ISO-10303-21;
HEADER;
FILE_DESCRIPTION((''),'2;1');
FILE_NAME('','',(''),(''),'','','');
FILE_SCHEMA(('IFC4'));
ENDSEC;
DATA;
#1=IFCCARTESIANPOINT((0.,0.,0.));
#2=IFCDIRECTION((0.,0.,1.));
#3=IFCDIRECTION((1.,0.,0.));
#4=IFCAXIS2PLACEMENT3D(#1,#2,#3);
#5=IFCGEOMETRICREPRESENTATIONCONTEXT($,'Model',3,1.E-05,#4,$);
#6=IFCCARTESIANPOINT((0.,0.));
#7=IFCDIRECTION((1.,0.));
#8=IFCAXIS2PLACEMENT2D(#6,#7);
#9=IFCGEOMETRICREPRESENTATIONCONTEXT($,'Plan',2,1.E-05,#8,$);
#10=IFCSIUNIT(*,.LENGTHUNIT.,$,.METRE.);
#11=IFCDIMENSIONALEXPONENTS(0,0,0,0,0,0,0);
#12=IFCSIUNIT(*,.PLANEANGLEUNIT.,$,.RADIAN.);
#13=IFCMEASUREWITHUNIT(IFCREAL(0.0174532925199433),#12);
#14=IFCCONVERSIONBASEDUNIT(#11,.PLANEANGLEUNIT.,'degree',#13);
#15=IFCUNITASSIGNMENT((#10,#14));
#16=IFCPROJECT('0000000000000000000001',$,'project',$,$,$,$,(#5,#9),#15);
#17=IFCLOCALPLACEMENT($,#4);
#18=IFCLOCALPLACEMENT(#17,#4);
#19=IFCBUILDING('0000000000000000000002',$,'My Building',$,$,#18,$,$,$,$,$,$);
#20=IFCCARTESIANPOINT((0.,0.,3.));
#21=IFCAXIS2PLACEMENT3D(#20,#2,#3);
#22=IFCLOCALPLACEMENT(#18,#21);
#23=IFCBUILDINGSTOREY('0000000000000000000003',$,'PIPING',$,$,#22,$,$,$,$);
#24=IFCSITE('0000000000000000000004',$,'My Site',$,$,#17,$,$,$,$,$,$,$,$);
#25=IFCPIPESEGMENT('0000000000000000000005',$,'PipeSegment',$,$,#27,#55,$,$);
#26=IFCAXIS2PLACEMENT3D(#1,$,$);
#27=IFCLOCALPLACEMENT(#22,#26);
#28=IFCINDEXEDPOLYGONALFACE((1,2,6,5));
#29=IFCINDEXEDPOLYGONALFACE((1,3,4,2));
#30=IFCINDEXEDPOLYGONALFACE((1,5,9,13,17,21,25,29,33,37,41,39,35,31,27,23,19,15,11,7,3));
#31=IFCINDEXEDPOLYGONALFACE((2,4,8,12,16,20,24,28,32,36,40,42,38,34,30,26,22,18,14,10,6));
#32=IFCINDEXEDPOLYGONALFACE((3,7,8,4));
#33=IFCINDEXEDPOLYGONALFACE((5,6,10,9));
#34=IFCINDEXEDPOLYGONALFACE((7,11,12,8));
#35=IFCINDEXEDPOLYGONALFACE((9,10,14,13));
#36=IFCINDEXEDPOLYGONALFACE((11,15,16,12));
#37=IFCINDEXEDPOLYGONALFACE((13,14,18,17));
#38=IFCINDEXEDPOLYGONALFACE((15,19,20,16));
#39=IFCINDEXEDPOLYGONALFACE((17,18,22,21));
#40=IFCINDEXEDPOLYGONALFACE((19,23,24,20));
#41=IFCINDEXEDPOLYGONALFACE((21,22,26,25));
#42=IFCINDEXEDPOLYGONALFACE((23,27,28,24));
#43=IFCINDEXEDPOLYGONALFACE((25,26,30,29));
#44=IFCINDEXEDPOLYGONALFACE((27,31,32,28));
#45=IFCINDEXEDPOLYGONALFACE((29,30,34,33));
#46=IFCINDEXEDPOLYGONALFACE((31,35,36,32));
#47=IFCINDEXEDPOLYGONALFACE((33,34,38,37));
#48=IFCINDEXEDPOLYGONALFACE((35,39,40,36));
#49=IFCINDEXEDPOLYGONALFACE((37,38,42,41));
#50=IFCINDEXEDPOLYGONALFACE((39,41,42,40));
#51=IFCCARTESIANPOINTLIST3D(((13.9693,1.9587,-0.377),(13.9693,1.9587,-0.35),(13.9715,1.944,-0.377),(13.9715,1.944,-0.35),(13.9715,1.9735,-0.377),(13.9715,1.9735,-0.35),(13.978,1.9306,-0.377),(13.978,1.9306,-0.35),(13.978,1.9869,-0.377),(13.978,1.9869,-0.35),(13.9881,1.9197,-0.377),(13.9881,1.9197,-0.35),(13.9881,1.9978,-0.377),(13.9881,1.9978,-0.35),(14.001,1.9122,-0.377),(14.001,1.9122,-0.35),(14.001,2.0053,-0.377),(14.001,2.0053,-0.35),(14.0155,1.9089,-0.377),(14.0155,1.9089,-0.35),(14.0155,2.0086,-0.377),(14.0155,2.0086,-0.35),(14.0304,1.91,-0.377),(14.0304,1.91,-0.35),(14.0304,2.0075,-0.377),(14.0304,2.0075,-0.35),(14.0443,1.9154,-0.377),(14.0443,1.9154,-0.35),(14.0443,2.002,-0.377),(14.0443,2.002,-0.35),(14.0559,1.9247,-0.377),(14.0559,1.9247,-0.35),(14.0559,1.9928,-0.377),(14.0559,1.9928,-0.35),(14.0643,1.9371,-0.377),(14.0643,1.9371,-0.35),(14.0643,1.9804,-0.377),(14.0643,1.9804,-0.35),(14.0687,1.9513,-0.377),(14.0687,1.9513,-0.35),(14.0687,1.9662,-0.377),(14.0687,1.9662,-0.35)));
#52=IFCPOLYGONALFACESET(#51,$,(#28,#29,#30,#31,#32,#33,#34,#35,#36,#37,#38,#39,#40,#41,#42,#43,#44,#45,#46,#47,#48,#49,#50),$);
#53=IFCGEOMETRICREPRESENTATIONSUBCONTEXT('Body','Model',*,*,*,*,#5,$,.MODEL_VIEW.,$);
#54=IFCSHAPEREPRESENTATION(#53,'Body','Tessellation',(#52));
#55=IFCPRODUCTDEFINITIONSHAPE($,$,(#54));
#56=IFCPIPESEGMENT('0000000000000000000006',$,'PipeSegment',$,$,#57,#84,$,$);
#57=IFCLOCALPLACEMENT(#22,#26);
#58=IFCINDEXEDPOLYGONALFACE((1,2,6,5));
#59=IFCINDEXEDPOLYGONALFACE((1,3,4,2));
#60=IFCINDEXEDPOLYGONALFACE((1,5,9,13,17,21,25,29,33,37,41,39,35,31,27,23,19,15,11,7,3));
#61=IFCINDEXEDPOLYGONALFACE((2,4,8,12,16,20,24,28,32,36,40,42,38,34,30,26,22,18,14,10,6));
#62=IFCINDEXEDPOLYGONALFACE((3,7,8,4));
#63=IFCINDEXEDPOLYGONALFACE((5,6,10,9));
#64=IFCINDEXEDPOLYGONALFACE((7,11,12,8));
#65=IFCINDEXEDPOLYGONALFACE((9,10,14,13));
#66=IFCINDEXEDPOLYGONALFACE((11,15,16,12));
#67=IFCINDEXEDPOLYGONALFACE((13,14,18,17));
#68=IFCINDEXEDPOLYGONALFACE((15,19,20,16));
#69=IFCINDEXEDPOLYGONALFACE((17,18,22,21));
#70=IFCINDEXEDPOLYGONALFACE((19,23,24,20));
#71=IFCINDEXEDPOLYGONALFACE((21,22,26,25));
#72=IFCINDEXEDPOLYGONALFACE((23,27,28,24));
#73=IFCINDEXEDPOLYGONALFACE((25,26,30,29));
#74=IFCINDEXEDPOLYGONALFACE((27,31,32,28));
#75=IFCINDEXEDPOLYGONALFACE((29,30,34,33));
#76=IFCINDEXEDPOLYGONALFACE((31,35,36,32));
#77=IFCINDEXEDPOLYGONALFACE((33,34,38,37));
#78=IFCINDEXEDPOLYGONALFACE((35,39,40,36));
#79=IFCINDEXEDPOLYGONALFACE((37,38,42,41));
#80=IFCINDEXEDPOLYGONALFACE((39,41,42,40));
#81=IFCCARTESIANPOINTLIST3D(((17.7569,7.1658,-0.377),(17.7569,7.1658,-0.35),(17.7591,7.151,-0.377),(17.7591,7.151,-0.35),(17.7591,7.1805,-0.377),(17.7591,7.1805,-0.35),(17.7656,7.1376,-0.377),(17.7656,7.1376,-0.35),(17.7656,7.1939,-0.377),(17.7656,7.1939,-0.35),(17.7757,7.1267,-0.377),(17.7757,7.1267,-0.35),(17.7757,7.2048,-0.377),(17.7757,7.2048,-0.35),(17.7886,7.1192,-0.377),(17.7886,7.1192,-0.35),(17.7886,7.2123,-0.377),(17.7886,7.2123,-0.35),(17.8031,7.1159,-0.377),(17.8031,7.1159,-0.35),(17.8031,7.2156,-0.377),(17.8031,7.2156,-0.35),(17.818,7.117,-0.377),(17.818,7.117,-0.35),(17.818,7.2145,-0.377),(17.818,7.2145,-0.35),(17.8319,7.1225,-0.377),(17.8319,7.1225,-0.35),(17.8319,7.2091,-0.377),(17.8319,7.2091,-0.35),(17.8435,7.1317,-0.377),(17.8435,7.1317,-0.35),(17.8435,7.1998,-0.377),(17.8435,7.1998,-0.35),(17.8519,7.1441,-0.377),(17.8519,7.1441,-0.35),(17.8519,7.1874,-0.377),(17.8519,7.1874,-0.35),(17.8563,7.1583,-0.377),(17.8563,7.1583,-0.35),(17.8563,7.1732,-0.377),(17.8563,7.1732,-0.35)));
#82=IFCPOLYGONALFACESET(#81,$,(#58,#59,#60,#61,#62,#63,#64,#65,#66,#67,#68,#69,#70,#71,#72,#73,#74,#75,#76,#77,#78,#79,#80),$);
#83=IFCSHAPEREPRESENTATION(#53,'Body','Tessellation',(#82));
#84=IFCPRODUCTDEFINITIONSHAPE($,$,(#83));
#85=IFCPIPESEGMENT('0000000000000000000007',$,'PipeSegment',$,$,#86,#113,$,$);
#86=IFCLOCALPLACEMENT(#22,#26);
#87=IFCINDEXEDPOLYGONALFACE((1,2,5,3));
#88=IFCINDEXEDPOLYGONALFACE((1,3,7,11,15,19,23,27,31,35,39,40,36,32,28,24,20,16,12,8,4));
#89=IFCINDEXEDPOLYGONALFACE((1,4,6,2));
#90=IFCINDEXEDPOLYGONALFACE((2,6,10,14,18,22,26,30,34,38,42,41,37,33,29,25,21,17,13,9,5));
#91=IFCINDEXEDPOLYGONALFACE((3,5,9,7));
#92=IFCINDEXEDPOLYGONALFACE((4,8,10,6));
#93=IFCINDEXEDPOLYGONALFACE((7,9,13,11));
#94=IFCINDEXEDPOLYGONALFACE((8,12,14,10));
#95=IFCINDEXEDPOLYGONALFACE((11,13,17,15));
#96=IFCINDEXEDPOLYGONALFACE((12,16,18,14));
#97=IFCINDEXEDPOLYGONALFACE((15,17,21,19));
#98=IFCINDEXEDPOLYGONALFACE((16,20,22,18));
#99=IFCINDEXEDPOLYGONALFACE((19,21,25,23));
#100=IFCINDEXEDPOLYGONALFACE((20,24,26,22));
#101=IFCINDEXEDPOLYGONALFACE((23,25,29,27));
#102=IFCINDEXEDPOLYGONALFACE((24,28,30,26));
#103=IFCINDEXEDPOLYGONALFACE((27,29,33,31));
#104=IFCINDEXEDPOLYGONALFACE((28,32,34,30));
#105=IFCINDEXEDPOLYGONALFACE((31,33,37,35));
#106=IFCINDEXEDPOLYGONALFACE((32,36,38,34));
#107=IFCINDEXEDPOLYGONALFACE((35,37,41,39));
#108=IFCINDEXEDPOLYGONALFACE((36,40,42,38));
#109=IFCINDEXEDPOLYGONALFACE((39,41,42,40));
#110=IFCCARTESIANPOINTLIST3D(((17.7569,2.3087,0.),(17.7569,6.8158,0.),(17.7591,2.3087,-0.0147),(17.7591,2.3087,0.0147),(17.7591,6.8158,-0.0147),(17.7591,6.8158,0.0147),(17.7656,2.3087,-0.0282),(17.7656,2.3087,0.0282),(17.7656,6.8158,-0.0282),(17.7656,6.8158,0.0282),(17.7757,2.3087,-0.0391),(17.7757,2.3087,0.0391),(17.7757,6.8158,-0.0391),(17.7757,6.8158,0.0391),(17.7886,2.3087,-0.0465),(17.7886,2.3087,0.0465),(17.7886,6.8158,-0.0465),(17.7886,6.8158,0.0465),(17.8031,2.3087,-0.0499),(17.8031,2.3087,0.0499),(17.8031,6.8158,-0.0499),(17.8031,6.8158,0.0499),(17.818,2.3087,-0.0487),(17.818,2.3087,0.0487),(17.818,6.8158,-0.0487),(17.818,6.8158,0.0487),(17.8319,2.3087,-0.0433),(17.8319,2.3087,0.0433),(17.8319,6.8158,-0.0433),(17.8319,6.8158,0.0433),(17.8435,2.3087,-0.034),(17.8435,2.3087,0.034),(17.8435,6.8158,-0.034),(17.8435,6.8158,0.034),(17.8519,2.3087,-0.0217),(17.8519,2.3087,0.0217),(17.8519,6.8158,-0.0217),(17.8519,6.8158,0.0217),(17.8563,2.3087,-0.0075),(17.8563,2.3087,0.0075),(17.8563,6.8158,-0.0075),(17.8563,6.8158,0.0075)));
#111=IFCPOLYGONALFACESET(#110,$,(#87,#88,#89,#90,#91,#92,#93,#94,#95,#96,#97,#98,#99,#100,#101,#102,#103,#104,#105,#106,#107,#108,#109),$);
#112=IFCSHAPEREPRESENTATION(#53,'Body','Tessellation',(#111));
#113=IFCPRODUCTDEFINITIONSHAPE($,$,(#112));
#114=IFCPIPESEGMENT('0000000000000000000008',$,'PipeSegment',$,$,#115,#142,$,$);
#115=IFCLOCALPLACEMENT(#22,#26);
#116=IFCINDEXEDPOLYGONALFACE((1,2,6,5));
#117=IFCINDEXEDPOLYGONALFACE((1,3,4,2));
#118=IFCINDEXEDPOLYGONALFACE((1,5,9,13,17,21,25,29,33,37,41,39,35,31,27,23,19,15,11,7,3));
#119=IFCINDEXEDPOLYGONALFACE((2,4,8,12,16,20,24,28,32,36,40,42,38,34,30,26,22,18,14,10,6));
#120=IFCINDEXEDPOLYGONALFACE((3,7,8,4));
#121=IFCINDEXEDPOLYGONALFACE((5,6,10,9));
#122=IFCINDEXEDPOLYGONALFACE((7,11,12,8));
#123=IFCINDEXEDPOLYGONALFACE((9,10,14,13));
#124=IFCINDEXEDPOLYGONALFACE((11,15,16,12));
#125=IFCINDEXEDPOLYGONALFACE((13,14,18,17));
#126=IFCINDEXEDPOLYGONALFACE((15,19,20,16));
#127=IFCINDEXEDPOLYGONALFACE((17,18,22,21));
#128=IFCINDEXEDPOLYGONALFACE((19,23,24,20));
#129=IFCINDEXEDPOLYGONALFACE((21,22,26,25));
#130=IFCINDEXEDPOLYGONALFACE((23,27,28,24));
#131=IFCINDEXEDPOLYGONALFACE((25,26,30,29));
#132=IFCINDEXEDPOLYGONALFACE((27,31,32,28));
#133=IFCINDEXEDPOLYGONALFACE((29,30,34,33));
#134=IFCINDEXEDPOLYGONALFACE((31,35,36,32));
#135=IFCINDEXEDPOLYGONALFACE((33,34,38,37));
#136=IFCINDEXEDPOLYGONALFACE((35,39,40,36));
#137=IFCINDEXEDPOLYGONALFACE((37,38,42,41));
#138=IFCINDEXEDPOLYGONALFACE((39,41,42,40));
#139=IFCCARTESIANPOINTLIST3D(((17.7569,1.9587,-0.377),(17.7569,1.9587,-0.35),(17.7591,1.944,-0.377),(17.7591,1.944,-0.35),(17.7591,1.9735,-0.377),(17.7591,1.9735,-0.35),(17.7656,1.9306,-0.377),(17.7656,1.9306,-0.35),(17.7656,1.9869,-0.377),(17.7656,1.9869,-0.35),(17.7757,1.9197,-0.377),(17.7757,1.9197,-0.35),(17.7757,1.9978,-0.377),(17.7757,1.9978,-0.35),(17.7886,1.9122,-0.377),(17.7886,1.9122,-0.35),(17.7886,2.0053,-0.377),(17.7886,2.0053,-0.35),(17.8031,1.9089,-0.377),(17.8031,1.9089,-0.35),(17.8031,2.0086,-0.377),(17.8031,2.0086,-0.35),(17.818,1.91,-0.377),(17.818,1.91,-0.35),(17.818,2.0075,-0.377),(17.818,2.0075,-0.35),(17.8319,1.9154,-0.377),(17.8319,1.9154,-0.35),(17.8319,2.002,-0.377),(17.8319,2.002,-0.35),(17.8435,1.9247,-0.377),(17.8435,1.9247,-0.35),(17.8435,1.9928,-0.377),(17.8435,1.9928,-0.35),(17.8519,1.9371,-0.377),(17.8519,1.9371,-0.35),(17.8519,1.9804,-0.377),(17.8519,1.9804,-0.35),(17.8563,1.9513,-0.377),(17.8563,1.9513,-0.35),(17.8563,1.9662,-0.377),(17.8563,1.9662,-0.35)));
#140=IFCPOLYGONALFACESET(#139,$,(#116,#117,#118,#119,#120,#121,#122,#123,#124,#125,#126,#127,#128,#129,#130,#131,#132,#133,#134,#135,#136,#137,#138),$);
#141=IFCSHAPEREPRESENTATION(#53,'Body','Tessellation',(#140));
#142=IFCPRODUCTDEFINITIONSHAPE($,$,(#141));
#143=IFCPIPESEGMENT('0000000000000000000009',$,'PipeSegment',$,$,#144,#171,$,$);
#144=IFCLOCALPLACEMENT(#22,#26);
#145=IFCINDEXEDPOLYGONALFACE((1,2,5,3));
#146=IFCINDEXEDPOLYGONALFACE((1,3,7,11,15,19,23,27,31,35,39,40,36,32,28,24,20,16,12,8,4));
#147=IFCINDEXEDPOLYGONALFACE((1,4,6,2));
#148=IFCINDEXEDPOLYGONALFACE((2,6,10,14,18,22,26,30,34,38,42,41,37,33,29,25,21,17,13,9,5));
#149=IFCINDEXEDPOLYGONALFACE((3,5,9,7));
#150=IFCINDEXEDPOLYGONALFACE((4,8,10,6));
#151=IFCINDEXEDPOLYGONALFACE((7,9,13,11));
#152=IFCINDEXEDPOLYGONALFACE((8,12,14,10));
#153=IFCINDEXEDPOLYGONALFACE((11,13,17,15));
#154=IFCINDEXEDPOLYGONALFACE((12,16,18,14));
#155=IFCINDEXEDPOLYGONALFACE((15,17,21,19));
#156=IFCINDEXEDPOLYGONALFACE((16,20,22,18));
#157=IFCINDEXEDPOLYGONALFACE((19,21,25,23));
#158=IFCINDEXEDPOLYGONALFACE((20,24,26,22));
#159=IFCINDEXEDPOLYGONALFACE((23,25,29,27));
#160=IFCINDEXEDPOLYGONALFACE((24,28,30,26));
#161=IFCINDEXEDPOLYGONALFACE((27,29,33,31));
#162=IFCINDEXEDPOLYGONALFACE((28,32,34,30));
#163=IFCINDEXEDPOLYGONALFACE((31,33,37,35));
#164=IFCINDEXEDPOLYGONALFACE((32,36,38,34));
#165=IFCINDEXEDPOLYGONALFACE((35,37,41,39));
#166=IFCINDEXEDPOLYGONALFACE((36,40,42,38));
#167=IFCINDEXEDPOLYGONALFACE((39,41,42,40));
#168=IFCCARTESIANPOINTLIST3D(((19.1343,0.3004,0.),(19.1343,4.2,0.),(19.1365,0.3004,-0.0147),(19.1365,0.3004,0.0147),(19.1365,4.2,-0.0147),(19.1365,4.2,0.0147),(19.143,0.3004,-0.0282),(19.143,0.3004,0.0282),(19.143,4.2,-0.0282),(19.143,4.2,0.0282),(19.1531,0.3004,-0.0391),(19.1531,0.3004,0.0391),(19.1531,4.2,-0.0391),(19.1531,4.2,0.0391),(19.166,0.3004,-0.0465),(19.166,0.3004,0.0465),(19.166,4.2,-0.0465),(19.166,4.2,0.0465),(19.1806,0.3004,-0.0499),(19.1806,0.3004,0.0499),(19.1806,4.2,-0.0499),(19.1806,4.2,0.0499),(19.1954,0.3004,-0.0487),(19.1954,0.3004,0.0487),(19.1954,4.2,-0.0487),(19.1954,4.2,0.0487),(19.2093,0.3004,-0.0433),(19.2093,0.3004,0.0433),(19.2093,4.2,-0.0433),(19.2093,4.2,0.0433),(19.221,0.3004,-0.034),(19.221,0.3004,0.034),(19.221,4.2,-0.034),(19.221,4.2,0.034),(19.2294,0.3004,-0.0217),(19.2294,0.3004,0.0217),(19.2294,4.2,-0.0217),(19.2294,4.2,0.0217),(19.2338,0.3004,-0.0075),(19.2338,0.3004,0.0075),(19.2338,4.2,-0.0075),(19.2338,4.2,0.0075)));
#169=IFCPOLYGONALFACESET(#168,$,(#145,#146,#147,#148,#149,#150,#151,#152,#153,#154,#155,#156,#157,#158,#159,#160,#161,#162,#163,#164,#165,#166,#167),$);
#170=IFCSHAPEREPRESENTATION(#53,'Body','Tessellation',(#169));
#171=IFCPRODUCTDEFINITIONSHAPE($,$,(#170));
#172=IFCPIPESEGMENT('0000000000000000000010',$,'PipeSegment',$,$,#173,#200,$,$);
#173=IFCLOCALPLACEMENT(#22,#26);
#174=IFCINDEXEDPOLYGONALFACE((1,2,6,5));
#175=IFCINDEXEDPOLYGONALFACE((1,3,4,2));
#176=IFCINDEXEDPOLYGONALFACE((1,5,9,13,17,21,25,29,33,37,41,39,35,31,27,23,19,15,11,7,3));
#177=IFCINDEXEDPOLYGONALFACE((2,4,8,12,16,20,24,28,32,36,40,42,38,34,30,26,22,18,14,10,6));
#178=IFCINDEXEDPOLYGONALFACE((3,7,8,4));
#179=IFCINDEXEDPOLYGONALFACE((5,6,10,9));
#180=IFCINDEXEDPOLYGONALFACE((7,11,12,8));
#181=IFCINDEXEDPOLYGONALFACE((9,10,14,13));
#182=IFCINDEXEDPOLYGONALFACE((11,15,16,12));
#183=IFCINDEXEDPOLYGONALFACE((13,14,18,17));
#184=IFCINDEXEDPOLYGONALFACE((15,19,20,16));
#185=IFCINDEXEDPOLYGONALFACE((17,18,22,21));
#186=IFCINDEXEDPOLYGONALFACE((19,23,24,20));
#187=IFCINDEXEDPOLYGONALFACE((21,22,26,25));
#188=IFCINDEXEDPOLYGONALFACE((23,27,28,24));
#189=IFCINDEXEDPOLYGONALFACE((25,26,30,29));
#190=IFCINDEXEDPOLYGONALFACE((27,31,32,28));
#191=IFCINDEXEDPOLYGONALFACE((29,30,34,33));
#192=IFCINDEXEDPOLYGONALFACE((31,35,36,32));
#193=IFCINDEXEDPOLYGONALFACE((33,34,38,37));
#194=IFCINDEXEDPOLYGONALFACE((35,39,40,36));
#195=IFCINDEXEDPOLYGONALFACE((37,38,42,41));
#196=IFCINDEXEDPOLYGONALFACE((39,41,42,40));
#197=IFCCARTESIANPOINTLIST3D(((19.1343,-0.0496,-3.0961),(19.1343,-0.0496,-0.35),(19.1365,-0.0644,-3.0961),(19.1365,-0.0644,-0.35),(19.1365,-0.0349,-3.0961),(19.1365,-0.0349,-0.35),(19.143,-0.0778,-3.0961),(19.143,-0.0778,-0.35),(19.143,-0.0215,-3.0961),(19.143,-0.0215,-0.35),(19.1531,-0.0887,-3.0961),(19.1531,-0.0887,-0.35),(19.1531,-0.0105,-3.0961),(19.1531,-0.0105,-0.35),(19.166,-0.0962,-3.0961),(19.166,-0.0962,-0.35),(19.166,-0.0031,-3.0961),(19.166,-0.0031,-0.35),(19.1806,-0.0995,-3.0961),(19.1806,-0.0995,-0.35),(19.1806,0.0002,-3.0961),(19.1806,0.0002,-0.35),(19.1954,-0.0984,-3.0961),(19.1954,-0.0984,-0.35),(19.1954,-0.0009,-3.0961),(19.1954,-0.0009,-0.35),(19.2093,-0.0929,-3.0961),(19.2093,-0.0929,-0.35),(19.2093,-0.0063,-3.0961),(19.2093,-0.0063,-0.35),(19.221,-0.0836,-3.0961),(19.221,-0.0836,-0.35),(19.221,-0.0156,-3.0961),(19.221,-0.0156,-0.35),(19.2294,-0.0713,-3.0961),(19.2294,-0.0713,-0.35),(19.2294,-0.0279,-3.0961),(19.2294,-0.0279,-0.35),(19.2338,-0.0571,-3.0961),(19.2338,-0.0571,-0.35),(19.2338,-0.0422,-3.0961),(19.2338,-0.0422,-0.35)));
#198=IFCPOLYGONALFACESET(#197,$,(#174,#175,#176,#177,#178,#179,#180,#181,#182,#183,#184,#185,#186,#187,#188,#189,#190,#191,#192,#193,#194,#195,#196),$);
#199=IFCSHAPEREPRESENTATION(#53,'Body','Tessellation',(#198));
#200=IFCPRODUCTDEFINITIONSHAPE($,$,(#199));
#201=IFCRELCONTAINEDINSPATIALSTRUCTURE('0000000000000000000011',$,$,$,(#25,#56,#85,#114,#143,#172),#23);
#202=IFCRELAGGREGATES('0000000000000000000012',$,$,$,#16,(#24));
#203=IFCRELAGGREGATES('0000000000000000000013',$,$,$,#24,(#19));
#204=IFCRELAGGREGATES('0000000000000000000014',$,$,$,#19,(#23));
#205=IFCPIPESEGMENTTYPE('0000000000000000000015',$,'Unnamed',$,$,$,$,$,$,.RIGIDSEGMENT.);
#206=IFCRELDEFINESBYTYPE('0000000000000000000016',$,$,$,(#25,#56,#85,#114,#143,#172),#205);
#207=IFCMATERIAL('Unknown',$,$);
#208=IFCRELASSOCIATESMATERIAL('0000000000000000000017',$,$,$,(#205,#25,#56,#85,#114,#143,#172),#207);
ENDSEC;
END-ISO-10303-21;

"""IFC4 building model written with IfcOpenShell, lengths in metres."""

from ifc_helpers import new_model, entity, si_unit, converted_unit, frame, origin_with_axes, origin_2d_with_axis, place, context, subcontext, project, spatial, circle, extrude, material, material_profile, profile_set, profile_usage, type_object, element, save


model = new_model("IFC4")

# Units and contexts
model_context = context("Model", 3, precision=1e-05, world=origin_with_axes())
plan_context = context("Plan", 2, precision=1e-05, world=origin_2d_with_axis())
body_context = subcontext(model_context, "Body", "Model", "MODEL_VIEW")
ifc_project = project(units=[si_unit("LENGTHUNIT", "METRE"), converted_unit("PLANEANGLEUNIT", "degree", entity("IfcReal", 0.0174532925199433), si_unit("PLANEANGLEUNIT", "RADIAN"), dimensions=[0, 0, 0, 0, 0, 0, 0])], contexts=[model_context, plan_context])

# Site, building, storey
site_placement = place(None, origin_with_axes())
site = spatial("IfcSite", under=ifc_project, at=site_placement, Name="My Site")
building_placement = place(site_placement, origin_with_axes())
building = spatial("IfcBuilding", under=site, at=building_placement, Name="My Building")
storey_placement = place(building_placement, frame((0.0, 0.0, 3.0), z_axis=(0.0, 0.0, 1.0), x_axis=(1.0, 0.0, 0.0)))
storey = spatial("IfcBuildingStorey", under=building, at=storey_placement, Name="PIPING")

# Pipe segments
ifc_material = material(Name="Unknown")
ifc_material_profile = material_profile(ifc_material, circle(Radius=0.05))
ifc_profile_set = profile_set([ifc_material_profile])
pipe_segment_type = type_object("IfcPipeSegmentType", Name="Unnamed", PredefinedType="RIGIDSEGMENT", material=ifc_profile_set)
ifc_profile_usage_1 = profile_usage(ifc_profile_set, cardinal=5)
pipe_segment_1_placement = place(storey_placement, frame((14.0193, 1.9587, -0.35), z_axis=(0.0, 0.0, -1.0), x_axis=(-1.0, 0.0, 0.0)))
element("IfcPipeSegment", 1, at=pipe_segment_1_placement, inside=storey, type_object=pipe_segment_type, material=ifc_profile_usage_1, Name="PipeSegment", context=body_context, shape_type="SweptSolid", body=[
    extrude(circle(Radius=0.05), origin_with_axes(), (0.0, 0.0, 1.0), 0.027),
])
ifc_profile_usage_2 = profile_usage(ifc_profile_set, cardinal=5)
pipe_segment_2_placement = place(storey_placement, frame((17.8069, 7.1658, -0.35), z_axis=(0.0, 0.0, -1.0), x_axis=(-1.0, 0.0, 0.0)))
element("IfcPipeSegment", 2, at=pipe_segment_2_placement, inside=storey, type_object=pipe_segment_type, material=ifc_profile_usage_2, Name="PipeSegment", context=body_context, shape_type="SweptSolid", body=[
    extrude(circle(Radius=0.05), origin_with_axes(), (0.0, 0.0, 1.0), 0.027),
])
ifc_profile_usage_3 = profile_usage(ifc_profile_set, cardinal=5)
pipe_segment_3_placement = place(storey_placement, frame((17.8069, 2.3087, 0.0), z_axis=(0.0, 1.0, 0.0), x_axis=(-1.0, 0.0, 0.0)))
element("IfcPipeSegment", 3, at=pipe_segment_3_placement, inside=storey, type_object=pipe_segment_type, material=ifc_profile_usage_3, Name="PipeSegment", context=body_context, shape_type="SweptSolid", body=[
    extrude(circle(Radius=0.05), origin_with_axes(), (0.0, 0.0, 1.0), 4.507),
])
ifc_profile_usage_4 = profile_usage(ifc_profile_set, cardinal=5)
pipe_segment_4_placement = place(storey_placement, frame((17.8069, 1.9587, -0.35), z_axis=(0.0, 0.0, -1.0), x_axis=(-1.0, 0.0, 0.0)))
element("IfcPipeSegment", 4, at=pipe_segment_4_placement, inside=storey, type_object=pipe_segment_type, material=ifc_profile_usage_4, Name="PipeSegment", context=body_context, shape_type="SweptSolid", body=[
    extrude(circle(Radius=0.05), origin_with_axes(), (0.0, 0.0, 1.0), 0.027),
])
ifc_profile_usage_5 = profile_usage(ifc_profile_set, cardinal=5)
pipe_segment_5_placement = place(storey_placement, frame((19.1843, 0.3004, 0.0), z_axis=(0.0, 1.0, 0.0), x_axis=(-1.0, 0.0, 0.0)))
element("IfcPipeSegment", 5, at=pipe_segment_5_placement, inside=storey, type_object=pipe_segment_type, material=ifc_profile_usage_5, Name="PipeSegment", context=body_context, shape_type="SweptSolid", body=[
    extrude(circle(Radius=0.05), origin_with_axes(), (0.0, 0.0, 1.0), 3.8996),
])
ifc_profile_usage_6 = profile_usage(ifc_profile_set, cardinal=5)
pipe_segment_6_placement = place(storey_placement, frame((19.1843, -0.0496, -3.0961), z_axis=(0.0, 0.0, 1.0), x_axis=(-1.0, 0.0, 0.0)))
element("IfcPipeSegment", 6, at=pipe_segment_6_placement, inside=storey, type_object=pipe_segment_type, material=ifc_profile_usage_6, Name="PipeSegment", context=body_context, shape_type="SweptSolid", body=[
    extrude(circle(Radius=0.05), origin_with_axes(), (0.0, 0.0, 1.0), 2.7461),
])

save(model, "model.ifc")
